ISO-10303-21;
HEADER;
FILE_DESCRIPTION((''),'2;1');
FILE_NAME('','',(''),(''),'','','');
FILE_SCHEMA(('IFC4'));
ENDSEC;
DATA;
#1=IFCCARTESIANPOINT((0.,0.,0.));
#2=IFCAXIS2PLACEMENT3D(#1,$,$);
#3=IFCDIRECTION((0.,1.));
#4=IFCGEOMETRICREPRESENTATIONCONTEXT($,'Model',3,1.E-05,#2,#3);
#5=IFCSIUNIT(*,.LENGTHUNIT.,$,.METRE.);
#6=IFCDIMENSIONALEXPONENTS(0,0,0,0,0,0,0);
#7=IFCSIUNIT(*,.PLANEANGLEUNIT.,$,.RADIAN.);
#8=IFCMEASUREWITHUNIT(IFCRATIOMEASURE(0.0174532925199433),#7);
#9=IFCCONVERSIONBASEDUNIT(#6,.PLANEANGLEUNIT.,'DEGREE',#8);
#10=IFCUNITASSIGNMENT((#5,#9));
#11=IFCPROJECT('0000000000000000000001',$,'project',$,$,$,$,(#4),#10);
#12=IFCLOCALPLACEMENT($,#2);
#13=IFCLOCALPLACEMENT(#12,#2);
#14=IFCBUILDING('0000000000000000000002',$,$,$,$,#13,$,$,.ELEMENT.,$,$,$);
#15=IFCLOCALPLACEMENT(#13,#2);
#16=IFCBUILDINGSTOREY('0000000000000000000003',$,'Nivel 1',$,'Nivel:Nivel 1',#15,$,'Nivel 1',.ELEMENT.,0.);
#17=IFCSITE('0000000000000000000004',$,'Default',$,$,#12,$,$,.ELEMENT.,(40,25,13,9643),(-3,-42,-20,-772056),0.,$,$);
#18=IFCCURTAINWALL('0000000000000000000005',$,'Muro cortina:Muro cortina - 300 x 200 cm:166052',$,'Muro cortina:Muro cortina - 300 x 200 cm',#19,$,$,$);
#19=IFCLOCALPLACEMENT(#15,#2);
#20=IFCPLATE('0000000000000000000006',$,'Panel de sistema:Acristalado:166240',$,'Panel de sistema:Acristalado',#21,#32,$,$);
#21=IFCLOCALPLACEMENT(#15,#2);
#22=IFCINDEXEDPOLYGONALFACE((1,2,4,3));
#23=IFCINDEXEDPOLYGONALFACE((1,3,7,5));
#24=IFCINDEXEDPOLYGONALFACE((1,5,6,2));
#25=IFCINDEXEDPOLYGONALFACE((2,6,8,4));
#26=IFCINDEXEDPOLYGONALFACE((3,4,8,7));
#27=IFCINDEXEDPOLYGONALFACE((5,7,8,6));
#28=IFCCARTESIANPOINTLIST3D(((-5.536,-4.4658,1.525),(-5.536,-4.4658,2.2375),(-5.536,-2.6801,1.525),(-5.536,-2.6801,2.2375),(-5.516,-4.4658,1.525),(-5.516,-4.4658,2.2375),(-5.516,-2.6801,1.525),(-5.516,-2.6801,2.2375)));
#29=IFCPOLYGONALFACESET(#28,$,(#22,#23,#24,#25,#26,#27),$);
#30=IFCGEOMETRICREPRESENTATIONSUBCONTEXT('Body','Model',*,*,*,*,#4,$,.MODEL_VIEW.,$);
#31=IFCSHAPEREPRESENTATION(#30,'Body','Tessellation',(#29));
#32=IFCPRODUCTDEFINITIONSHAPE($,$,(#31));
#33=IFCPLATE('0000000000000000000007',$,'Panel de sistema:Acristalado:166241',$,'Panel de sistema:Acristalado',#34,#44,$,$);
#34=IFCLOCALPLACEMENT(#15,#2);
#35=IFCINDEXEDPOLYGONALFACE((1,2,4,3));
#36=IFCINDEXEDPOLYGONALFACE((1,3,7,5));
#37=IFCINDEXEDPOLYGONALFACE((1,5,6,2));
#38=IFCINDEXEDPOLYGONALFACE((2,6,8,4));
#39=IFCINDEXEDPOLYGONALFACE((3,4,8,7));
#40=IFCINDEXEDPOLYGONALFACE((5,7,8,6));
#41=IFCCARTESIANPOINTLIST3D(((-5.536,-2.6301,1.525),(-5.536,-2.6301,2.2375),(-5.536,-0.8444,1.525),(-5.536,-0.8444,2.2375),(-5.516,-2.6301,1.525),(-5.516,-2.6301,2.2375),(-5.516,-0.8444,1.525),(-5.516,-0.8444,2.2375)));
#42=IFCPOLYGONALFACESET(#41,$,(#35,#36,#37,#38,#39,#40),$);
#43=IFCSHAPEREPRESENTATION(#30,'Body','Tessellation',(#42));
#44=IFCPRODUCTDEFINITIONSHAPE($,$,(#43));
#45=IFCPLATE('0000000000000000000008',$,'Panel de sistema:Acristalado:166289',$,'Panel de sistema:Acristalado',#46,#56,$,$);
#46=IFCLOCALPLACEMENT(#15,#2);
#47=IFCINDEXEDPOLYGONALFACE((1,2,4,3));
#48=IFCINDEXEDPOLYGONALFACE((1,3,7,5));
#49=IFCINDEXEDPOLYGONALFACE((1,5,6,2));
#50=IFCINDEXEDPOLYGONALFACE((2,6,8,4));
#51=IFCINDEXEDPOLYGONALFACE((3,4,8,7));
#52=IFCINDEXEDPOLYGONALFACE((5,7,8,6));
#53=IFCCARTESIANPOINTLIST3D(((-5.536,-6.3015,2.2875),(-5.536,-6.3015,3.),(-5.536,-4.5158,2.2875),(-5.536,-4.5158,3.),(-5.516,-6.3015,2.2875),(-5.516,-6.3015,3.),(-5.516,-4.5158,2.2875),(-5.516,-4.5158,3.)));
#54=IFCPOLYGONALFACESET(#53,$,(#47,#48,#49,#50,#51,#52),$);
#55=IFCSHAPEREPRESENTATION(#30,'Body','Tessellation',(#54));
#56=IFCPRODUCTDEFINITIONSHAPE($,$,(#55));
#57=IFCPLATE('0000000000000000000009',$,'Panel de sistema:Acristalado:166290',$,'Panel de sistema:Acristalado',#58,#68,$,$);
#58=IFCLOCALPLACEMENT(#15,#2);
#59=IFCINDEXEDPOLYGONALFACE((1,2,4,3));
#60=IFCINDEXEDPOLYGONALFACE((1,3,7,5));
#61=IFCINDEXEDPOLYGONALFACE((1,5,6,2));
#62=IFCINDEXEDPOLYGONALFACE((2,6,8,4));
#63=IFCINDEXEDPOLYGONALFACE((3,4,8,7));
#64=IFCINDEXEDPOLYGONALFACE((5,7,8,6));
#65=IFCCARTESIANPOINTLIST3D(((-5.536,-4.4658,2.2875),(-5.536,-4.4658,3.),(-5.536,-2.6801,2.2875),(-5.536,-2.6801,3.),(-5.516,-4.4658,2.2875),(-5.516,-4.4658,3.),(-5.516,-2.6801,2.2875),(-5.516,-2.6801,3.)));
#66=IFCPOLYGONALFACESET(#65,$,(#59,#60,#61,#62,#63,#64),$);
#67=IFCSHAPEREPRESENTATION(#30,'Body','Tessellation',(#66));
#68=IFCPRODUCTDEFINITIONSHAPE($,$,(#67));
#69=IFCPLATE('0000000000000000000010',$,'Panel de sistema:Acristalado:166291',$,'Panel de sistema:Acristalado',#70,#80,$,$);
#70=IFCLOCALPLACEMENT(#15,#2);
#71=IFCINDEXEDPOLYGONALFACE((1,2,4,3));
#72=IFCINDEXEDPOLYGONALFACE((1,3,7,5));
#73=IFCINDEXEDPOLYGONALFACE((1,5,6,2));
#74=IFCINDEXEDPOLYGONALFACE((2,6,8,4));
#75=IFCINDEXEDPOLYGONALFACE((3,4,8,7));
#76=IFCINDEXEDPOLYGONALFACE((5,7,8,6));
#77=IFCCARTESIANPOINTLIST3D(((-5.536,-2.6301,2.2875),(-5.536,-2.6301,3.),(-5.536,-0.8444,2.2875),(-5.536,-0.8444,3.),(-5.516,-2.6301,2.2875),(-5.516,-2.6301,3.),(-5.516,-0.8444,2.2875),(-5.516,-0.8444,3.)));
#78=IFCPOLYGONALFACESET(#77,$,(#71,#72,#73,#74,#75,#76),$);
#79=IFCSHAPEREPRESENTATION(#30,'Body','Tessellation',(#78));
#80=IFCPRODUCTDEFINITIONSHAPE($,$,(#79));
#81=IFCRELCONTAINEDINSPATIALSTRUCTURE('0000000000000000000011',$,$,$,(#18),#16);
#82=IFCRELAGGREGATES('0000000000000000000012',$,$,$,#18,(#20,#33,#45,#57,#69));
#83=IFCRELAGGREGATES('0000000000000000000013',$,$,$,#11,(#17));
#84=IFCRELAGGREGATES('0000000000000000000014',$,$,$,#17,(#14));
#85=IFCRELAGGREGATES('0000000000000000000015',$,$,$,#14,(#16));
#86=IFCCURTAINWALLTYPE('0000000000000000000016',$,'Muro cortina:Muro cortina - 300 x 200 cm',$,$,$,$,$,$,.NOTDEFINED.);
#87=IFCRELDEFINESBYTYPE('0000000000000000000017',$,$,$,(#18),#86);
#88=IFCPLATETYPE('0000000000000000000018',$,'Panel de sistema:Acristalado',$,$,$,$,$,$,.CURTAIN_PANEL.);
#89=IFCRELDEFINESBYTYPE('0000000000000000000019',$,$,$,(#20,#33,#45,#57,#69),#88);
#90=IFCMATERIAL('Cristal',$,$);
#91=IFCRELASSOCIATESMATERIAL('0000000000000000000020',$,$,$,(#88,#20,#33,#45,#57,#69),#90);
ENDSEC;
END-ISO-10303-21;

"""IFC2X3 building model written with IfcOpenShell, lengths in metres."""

from ifc_helpers import new_model, entity, si_unit, converted_unit, direction, frame, origin, origin_2d_with_axis, place, context, subcontext, project, spatial, rectangle, extrude, source, transform, mapped, material, type_object, type_shapes, element, aggregate, save


model = new_model("IFC2X3")

# Units and contexts
model_context = context("Model", 3, precision=1e-05, world=origin(), true_north=direction((0.0, 1.0)))
body_context = subcontext(model_context, "Body", "Model", "MODEL_VIEW")
ifc_project = project(units=[si_unit("LENGTHUNIT", "METRE"), converted_unit("PLANEANGLEUNIT", "DEGREE", entity("IfcRatioMeasure", 0.0174532925199433), si_unit("PLANEANGLEUNIT", "RADIAN"), dimensions=[0, 0, 0, 0, 0, 0, 0])], contexts=[model_context])

# Site, building, storey
site_placement = place(None, origin())
site = spatial("IfcSite", under=ifc_project, at=site_placement, Name="Default", CompositionType="ELEMENT", RefLatitude=(40, 25, 13, 9643), RefLongitude=(-3, -42, -20, -772056), RefElevation=0.0)
building_placement = place(site_placement, origin())
building = spatial("IfcBuilding", under=site, at=building_placement, CompositionType="ELEMENT")
storey_placement = place(building_placement, origin())
storey = spatial("IfcBuildingStorey", under=building, at=storey_placement, Name="Nivel 1", ObjectType="Nivel:Nivel 1", LongName="Nivel 1", CompositionType="ELEMENT", Elevation=0.0)

# Curtain wall, plates
curtain_wall_type = type_object("IfcCurtainWallType", Name="Muro cortina:Muro cortina - 300 x 200 cm", PredefinedType="NOTDEFINED")
curtain_wall_placement = place(storey_placement, origin())
curtain_wall = element("IfcCurtainWall", 1, at=curtain_wall_placement, inside=storey, type_object=curtain_wall_type, Name="Muro cortina:Muro cortina - 300 x 200 cm:166052", ObjectType="Muro cortina:Muro cortina - 300 x 200 cm")
ifc_material_1 = material(Name="Cristal")
plate_type = type_object("IfcPlateType", Name="Panel de sistema:Acristalado", PredefinedType="CURTAIN_PANEL", material=ifc_material_1)
shared_shape_1 = source(origin(), body_context, "Body", "SweptSolid", [
    extrude(rectangle(XDim=0.02, YDim=1.7857, at=origin_2d_with_axis()), frame((0.0, 0.0, 0.0), z_axis=(0.0, 0.0, 1.0), x_axis=(0.0, 1.0, 0.0)), (0.0, 0.0, 1.0), 0.7125),
])
type_shapes(plate_type, [shared_shape_1])
plate_1_placement = place(curtain_wall_placement, frame((-5.526, -3.573, 1.525), z_axis=(0.0, 0.0, 1.0), x_axis=(0.0, 1.0, 0.0)))
plate_1 = element("IfcPlate", 2, at=plate_1_placement, type_object=plate_type, material=ifc_material_1, Name="Panel de sistema:Acristalado:166240", ObjectType="Panel de sistema:Acristalado", context=body_context, shape_type="MappedRepresentation", body=[
    mapped(shared_shape_1, transform((0.0, 0.0, 0.0), scale=1.0)),
])
plate_2_placement = place(curtain_wall_placement, frame((-5.526, -1.7373, 1.525), z_axis=(0.0, 0.0, 1.0), x_axis=(0.0, 1.0, 0.0)))
plate_2 = element("IfcPlate", 3, at=plate_2_placement, type_object=plate_type, material=ifc_material_1, Name="Panel de sistema:Acristalado:166241", ObjectType="Panel de sistema:Acristalado", context=body_context, shape_type="MappedRepresentation", body=[
    mapped(shared_shape_1, transform((0.0, 0.0, 0.0), scale=1.0)),
])
plate_3_placement = place(curtain_wall_placement, frame((-5.526, -5.4087, 2.2875), z_axis=(0.0, 0.0, 1.0), x_axis=(0.0, 1.0, 0.0)))
plate_3 = element("IfcPlate", 4, at=plate_3_placement, type_object=plate_type, material=ifc_material_1, Name="Panel de sistema:Acristalado:166289", ObjectType="Panel de sistema:Acristalado", context=body_context, shape_type="MappedRepresentation", body=[
    mapped(shared_shape_1, transform((0.0, 0.0, 0.0), scale=1.0)),
])
plate_4_placement = place(curtain_wall_placement, frame((-5.526, -3.573, 2.2875), z_axis=(0.0, 0.0, 1.0), x_axis=(0.0, 1.0, 0.0)))
plate_4 = element("IfcPlate", 5, at=plate_4_placement, type_object=plate_type, material=ifc_material_1, Name="Panel de sistema:Acristalado:166290", ObjectType="Panel de sistema:Acristalado", context=body_context, shape_type="MappedRepresentation", body=[
    mapped(shared_shape_1, transform((0.0, 0.0, 0.0), scale=1.0)),
])
plate_5_placement = place(curtain_wall_placement, frame((-5.526, -1.7373, 2.2875), z_axis=(0.0, 0.0, 1.0), x_axis=(0.0, 1.0, 0.0)))
plate_5 = element("IfcPlate", 6, at=plate_5_placement, type_object=plate_type, material=ifc_material_1, Name="Panel de sistema:Acristalado:166291", ObjectType="Panel de sistema:Acristalado", context=body_context, shape_type="MappedRepresentation", body=[
    mapped(shared_shape_1, transform((0.0, 0.0, 0.0), scale=1.0)),
])
aggregate(curtain_wall, [plate_1, plate_2, plate_3, plate_4, plate_5])

save(model, "model.ifc")
